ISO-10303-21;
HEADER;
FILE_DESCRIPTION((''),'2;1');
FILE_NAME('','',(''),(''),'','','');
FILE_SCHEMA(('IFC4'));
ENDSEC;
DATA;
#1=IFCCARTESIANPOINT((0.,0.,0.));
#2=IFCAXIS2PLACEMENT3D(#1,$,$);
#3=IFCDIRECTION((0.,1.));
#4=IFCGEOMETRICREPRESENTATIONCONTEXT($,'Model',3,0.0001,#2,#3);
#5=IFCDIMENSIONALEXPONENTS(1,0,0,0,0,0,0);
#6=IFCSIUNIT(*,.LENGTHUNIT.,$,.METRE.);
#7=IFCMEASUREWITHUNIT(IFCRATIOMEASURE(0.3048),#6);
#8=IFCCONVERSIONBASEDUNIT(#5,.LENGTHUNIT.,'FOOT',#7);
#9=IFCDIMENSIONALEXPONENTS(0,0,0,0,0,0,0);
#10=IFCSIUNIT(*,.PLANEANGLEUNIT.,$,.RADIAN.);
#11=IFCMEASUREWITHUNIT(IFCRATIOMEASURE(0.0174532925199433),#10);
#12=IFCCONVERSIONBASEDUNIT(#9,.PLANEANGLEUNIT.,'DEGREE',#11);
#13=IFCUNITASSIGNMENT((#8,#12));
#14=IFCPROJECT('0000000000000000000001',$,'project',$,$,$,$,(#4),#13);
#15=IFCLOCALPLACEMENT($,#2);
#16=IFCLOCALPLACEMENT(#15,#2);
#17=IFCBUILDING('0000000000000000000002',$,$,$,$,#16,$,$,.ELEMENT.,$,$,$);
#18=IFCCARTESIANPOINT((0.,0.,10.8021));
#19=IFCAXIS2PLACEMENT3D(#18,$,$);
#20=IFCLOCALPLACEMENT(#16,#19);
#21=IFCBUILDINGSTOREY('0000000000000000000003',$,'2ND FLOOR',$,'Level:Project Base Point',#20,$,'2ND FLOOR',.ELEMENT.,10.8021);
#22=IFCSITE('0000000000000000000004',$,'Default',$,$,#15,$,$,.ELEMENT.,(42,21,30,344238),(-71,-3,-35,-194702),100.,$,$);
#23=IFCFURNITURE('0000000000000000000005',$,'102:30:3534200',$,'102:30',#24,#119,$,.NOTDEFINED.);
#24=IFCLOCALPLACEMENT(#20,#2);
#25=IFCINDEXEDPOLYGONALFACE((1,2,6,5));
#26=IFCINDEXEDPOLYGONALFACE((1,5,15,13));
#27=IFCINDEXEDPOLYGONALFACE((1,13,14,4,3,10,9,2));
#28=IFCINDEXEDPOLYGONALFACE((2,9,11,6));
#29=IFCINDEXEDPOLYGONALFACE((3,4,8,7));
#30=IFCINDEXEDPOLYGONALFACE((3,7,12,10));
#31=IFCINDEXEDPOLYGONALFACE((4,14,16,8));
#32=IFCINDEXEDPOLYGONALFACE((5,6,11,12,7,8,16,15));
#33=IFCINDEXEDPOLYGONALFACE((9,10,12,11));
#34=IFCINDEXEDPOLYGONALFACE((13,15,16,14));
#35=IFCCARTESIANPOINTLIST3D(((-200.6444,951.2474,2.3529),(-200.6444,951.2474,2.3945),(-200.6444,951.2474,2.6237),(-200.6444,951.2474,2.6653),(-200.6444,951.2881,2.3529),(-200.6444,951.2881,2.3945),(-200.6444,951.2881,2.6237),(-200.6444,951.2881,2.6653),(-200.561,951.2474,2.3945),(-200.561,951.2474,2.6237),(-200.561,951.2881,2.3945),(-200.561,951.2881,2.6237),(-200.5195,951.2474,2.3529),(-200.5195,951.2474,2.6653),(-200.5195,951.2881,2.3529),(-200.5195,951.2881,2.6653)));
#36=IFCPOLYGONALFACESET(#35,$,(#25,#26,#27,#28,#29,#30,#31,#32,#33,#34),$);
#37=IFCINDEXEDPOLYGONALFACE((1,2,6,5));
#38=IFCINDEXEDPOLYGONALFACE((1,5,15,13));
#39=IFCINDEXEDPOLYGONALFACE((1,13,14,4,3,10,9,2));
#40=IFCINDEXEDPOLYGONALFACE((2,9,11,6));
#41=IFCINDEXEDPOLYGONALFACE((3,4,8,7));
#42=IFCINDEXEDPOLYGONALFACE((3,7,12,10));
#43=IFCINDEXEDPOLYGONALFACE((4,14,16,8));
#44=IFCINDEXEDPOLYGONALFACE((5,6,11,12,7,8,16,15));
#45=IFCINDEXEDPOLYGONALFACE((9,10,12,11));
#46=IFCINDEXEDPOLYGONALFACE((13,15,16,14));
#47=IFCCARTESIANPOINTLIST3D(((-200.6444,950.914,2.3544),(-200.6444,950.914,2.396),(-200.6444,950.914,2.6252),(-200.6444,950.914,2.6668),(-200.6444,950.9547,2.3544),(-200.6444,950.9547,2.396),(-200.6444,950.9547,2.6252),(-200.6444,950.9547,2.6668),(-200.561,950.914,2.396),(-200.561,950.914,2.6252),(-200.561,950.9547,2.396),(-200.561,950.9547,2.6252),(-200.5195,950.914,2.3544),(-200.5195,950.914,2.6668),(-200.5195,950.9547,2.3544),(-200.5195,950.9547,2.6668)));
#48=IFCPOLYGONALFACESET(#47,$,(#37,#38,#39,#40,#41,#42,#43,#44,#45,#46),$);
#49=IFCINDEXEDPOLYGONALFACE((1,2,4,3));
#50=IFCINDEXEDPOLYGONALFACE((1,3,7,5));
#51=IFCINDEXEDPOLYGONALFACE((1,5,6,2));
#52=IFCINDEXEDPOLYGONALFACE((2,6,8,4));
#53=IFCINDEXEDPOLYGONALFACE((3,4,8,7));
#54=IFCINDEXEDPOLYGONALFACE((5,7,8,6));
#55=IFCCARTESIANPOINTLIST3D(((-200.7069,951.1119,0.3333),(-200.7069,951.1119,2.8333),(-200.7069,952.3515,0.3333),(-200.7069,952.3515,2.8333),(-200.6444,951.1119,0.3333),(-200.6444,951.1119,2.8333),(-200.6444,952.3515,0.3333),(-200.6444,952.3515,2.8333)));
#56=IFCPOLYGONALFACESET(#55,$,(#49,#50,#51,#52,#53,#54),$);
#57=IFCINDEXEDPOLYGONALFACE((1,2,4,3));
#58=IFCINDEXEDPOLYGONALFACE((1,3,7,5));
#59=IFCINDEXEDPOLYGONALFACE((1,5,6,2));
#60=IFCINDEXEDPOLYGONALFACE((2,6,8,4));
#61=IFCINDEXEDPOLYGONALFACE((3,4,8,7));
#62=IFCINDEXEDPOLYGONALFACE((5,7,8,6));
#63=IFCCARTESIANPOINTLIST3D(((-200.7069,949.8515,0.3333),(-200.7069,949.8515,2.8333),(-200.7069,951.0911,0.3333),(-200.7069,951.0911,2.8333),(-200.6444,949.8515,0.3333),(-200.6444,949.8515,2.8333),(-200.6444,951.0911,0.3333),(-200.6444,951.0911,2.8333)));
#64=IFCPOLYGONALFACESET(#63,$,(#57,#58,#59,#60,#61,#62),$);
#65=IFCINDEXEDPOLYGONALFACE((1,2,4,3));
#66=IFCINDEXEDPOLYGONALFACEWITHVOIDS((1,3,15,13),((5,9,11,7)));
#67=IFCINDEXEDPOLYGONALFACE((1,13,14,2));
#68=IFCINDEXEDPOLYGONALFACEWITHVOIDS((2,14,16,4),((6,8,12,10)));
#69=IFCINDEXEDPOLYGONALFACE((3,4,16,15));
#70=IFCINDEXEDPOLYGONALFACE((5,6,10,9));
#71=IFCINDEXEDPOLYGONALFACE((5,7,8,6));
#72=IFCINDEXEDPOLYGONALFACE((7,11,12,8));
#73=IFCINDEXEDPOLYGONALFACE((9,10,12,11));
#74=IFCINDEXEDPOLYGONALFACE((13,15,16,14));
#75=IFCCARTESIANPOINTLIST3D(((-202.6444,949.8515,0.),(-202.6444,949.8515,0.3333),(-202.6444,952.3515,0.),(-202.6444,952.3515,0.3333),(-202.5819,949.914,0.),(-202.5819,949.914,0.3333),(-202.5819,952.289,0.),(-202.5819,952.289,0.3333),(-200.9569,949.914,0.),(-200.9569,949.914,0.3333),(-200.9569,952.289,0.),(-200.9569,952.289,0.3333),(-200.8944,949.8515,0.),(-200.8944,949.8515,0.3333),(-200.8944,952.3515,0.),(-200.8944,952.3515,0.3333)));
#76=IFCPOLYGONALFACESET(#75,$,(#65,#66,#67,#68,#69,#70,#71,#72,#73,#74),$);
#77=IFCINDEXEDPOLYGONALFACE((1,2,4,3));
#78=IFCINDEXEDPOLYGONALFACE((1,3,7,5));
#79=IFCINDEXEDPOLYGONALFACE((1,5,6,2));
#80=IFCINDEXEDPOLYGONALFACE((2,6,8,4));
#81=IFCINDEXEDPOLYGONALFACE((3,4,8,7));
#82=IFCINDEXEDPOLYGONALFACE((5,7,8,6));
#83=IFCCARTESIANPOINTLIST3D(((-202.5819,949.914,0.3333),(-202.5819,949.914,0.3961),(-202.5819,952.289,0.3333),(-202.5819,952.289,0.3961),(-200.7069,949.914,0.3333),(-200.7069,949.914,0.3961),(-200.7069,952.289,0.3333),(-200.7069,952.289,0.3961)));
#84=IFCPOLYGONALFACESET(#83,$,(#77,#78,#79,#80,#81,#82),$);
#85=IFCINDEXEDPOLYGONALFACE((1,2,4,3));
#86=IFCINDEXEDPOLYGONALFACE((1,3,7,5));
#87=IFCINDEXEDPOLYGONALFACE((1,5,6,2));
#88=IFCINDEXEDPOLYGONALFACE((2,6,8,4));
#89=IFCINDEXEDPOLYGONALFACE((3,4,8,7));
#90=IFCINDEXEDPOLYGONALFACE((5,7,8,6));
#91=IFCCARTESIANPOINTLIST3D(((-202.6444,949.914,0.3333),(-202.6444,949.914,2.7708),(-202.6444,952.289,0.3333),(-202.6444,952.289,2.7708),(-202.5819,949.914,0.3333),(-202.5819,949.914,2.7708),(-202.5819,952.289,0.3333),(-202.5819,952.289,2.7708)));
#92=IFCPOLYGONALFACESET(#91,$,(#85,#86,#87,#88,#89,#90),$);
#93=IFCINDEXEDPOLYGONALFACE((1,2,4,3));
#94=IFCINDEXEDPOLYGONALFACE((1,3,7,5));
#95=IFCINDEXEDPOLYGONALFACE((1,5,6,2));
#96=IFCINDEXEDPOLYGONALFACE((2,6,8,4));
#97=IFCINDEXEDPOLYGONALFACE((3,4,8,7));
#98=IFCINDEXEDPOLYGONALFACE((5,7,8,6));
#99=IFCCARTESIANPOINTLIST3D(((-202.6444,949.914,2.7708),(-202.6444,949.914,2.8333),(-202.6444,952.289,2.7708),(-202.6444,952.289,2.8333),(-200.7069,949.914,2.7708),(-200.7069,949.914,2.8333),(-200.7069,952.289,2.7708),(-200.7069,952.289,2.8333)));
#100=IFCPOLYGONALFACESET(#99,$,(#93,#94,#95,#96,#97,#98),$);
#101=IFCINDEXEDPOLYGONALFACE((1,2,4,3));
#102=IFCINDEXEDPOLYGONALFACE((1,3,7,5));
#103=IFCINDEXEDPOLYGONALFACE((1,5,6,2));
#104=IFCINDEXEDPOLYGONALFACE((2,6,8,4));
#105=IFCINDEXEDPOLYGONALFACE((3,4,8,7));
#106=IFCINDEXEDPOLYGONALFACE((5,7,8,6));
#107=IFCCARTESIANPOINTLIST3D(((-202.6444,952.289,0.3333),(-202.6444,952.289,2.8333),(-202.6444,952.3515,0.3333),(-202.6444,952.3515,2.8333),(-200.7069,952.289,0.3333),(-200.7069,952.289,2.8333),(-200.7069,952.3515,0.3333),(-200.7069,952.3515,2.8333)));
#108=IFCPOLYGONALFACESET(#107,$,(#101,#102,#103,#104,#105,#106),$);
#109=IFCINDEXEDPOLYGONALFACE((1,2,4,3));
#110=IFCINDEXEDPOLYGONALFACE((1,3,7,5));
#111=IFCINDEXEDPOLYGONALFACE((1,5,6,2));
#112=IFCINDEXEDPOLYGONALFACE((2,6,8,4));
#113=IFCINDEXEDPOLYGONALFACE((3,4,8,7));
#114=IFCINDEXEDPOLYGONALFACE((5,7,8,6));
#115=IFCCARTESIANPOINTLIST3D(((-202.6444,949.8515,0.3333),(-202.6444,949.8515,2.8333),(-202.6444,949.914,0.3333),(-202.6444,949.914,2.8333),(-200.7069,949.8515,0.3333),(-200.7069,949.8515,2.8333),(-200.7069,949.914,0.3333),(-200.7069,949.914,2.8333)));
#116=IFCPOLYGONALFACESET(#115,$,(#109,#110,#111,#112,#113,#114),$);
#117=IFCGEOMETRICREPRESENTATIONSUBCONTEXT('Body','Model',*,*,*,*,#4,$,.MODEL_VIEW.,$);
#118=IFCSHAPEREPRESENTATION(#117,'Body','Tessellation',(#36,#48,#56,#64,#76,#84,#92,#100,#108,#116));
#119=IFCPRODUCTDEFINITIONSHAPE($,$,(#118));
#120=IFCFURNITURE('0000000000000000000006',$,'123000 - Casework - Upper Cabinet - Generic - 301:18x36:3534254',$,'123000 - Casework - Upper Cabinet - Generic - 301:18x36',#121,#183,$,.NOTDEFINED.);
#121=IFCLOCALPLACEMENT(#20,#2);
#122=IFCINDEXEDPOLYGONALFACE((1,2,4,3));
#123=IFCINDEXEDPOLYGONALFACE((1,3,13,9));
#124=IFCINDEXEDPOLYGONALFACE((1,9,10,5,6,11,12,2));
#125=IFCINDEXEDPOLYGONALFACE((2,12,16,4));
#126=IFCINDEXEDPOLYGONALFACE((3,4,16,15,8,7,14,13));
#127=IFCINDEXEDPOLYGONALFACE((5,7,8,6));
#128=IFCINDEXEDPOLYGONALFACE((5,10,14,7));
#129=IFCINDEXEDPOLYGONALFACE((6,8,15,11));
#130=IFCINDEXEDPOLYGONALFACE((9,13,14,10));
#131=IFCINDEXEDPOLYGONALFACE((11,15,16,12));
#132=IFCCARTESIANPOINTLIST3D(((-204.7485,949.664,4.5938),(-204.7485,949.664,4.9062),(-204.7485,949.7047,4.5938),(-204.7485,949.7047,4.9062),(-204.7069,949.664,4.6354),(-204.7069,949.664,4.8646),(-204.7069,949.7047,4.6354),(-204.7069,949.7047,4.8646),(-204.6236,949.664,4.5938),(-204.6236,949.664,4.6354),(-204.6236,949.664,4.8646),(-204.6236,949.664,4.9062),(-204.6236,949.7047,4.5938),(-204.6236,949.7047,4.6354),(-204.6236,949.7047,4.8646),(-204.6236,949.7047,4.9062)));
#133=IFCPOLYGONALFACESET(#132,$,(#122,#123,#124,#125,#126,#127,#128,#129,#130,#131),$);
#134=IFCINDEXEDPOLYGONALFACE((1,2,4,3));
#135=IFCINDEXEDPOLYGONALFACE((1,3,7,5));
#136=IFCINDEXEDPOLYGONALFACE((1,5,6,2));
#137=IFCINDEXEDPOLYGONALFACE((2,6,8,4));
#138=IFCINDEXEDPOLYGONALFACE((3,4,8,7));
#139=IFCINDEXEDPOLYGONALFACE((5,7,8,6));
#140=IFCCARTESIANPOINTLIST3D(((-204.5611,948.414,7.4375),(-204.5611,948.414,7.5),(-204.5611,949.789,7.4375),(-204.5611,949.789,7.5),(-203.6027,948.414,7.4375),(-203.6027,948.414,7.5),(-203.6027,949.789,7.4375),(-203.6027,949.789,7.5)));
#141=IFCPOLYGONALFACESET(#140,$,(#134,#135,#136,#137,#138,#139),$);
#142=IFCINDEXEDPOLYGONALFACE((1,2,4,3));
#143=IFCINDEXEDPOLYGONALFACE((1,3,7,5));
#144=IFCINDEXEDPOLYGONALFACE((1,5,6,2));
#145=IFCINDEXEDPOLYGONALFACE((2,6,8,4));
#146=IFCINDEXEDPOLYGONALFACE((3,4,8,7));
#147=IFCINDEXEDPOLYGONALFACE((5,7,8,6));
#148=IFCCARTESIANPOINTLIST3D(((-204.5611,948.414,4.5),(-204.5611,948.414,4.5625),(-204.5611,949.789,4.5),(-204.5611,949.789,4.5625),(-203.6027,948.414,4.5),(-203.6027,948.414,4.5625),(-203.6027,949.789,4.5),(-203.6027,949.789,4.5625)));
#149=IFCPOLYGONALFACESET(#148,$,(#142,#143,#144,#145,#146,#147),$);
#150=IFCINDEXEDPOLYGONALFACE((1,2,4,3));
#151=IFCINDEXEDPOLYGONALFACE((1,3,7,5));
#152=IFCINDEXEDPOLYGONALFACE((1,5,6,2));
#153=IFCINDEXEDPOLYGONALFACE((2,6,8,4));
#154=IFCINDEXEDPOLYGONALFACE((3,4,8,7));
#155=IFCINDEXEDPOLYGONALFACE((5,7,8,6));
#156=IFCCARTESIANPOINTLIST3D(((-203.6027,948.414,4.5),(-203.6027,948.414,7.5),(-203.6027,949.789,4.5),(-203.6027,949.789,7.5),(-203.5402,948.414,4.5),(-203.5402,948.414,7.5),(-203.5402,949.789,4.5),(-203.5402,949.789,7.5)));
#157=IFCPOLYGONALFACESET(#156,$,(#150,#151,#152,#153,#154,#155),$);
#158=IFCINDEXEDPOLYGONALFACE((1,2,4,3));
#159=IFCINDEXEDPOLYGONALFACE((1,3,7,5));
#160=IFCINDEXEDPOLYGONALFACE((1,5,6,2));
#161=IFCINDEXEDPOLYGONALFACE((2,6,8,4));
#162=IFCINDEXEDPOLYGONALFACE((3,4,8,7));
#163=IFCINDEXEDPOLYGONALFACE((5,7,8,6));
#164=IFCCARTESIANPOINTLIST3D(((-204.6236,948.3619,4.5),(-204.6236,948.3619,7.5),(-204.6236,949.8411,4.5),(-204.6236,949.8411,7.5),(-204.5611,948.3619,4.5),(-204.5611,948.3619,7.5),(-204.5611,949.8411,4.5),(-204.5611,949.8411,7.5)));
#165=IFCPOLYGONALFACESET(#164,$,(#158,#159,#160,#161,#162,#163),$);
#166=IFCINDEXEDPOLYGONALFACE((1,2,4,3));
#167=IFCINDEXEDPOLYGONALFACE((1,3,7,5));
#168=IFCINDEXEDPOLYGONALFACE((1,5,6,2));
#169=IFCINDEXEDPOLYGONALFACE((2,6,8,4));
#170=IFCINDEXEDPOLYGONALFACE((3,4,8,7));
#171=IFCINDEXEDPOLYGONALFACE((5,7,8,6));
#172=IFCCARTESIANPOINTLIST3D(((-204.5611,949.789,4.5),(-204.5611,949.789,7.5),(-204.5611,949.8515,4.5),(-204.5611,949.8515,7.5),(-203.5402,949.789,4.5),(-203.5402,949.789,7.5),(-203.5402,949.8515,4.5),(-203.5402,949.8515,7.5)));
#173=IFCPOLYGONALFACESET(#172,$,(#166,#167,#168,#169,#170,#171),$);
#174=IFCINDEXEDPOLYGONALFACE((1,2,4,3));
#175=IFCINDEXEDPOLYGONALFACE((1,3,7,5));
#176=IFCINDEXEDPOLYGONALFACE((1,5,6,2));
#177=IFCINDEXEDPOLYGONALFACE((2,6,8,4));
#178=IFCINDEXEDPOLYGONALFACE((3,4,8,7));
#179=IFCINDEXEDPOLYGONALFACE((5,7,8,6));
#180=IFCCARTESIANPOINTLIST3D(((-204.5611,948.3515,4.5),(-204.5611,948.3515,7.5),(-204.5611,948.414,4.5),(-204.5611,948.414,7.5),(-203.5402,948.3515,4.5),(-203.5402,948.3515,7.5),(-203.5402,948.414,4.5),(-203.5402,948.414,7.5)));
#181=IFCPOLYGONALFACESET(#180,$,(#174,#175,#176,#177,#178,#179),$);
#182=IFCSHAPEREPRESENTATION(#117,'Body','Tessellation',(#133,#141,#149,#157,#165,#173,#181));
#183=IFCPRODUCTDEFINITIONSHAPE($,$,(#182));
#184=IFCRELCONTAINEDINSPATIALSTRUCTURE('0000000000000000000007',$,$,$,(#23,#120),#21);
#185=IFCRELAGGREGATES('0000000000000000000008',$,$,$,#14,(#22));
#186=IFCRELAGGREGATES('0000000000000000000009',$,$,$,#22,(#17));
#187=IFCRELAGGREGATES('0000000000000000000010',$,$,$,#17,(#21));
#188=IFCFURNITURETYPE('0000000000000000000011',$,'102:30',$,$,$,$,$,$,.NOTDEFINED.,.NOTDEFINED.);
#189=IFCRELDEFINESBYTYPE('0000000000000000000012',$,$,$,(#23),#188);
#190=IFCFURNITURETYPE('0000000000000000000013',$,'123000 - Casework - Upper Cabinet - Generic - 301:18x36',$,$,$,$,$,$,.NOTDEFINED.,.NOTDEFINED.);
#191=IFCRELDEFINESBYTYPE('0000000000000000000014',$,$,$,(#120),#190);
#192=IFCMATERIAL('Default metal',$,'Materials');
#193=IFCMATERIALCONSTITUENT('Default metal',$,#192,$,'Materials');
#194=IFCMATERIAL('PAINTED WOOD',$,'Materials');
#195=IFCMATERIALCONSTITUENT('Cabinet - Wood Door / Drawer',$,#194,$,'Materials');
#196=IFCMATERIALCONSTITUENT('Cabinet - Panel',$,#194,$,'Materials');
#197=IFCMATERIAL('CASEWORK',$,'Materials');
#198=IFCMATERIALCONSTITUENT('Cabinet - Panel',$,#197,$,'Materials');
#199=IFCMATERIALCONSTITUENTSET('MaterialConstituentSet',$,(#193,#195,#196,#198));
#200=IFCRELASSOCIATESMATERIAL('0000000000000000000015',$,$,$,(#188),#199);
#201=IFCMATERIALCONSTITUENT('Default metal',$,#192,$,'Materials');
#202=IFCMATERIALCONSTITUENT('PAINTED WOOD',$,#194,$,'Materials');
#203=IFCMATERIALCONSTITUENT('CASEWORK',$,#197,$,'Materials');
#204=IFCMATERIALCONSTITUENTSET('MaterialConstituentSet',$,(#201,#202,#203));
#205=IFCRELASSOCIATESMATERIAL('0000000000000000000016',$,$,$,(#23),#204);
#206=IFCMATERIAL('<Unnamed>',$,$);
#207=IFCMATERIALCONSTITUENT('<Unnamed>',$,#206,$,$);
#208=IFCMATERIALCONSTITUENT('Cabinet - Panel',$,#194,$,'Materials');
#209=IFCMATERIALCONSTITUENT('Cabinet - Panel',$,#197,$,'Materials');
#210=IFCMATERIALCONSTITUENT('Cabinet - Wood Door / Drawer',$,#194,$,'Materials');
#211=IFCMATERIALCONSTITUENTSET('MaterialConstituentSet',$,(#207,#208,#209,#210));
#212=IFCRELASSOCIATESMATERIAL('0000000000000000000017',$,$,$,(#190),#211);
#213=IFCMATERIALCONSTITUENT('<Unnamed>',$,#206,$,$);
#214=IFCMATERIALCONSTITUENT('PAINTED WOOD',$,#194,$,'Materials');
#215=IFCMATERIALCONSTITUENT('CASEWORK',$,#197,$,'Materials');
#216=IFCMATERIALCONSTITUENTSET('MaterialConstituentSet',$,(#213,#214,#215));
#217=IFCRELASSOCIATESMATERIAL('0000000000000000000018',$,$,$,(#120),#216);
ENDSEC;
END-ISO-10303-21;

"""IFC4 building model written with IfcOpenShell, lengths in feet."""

from ifc_helpers import new_model, entity, si_unit, converted_unit, direction, frame, frame_2d, origin, origin_2d_with_axis, place, context, subcontext, project, spatial, polyline, rectangle, outline, extrude, source, transform, mapped, material, constituent, constituent_set, type_object, type_shapes, element, save


model = new_model("IFC4")

# Units and contexts
model_context = context("Model", 3, precision=0.0001, world=origin(), true_north=direction((0.0, 1.0)))
body_context = subcontext(model_context, "Body", "Model", "MODEL_VIEW")
ifc_project = project(units=[converted_unit("LENGTHUNIT", "FOOT", entity("IfcRatioMeasure", 0.3048), si_unit("LENGTHUNIT", "METRE"), dimensions=[1, 0, 0, 0, 0, 0, 0]), converted_unit("PLANEANGLEUNIT", "DEGREE", entity("IfcRatioMeasure", 0.0174532925199433), si_unit("PLANEANGLEUNIT", "RADIAN"), dimensions=[0, 0, 0, 0, 0, 0, 0])], contexts=[model_context])

# Site, building, storey
site_placement = place(None, origin())
site = spatial("IfcSite", under=ifc_project, at=site_placement, Name="Default", CompositionType="ELEMENT", RefLatitude=(42, 21, 30, 344238), RefLongitude=(-71, -3, -35, -194702), RefElevation=100.0)
building_placement = place(site_placement, origin())
building = spatial("IfcBuilding", under=site, at=building_placement, CompositionType="ELEMENT")
storey_placement = place(building_placement, frame((0.0, 0.0, 10.8021)))
storey = spatial("IfcBuildingStorey", under=building, at=storey_placement, Name="2ND FLOOR", ObjectType="Level:Project Base Point", LongName="2ND FLOOR", CompositionType="ELEMENT", Elevation=10.8021)

# Furniture
ifc_material_1 = material(Name="<Unnamed>")
ifc_material_2 = material(Name="CASEWORK", Category="Materials")
ifc_material_3 = material(Name="PAINTED WOOD", Category="Materials")
ifc_material_4 = material(Name="Default metal", Category="Materials")
ifc_constituent_1 = constituent(ifc_material_4, Name="Default metal", Category="Materials")
ifc_constituent_2 = constituent(ifc_material_3, Name="PAINTED WOOD", Category="Materials")
ifc_constituent_3 = constituent(ifc_material_2, Name="CASEWORK", Category="Materials")
ifc_constituent_set_1 = constituent_set(constituents=[ifc_constituent_1, ifc_constituent_2, ifc_constituent_3], Name="MaterialConstituentSet")
ifc_constituent_4 = constituent(ifc_material_4, Name="Default metal", Category="Materials")
ifc_constituent_5 = constituent(ifc_material_3, Name="Cabinet - Wood Door / Drawer", Category="Materials")
ifc_constituent_6 = constituent(ifc_material_3, Name="Cabinet - Panel", Category="Materials")
ifc_constituent_7 = constituent(ifc_material_2, Name="Cabinet - Panel", Category="Materials")
ifc_constituent_set_2 = constituent_set(constituents=[ifc_constituent_4, ifc_constituent_5, ifc_constituent_6, ifc_constituent_7], Name="MaterialConstituentSet")
furniture_type_1 = type_object("IfcFurnitureType", Name="102:30", AssemblyPlace="NOTDEFINED", PredefinedType="NOTDEFINED", material=ifc_constituent_set_2)
shared_shape_1 = source(origin(), body_context, "Body", "SweptSolid", [
    extrude(outline(polyline([(0.1146, -0.0521), (0.1562, -0.0521), (0.1562, 0.0729), (-0.1562, 0.0729), (-0.1562, -0.0521), (-0.1146, -0.0521), (-0.1146, 0.0313), (0.1146, 0.0313), (0.1146, -0.0521)])), frame((0.2073, -2.0521, 2.5091), z_axis=(1.0, 0.0, 0.0), x_axis=(0.0, 0.0, 1.0)), (0.0, 0.0, 1.0), 0.0407),
    extrude(outline(polyline([(0.1146, -0.0521), (0.1562, -0.0521), (0.1562, 0.0729), (-0.1562, 0.0729), (-0.1562, -0.0521), (-0.1146, -0.0521), (-0.1146, 0.0313), (0.1146, 0.0313), (0.1146, -0.0521)])), frame((-0.126, -2.0521, 2.5106), z_axis=(1.0, 0.0, 0.0), x_axis=(0.0, 0.0, 1.0)), (0.0, 0.0, 1.0), 0.0407),
    extrude(rectangle(XDim=0.0625, YDim=1.2396, at=frame_2d((0.0, 0.0), x_axis=(1.0, 0.0))), frame((0.6917, -1.9688, 0.3333), z_axis=(0.0, 0.0, 1.0), x_axis=(0.0, 1.0, 0.0)), (0.0, 0.0, 1.0), 2.5),
    extrude(rectangle(XDim=0.0625, YDim=1.2396, at=origin_2d_with_axis()), frame((-0.5687, -1.9688, 0.3333), z_axis=(0.0, 0.0, 1.0), x_axis=(0.0, 1.0, 0.0)), (0.0, 0.0, 1.0), 2.5),
    extrude(outline(polyline([(-1.25, -0.875), (1.25, -0.875), (1.25, 0.875), (-1.25, 0.875), (-1.25, -0.875)]), holes=[polyline([(-1.1875, -0.8125), (-1.1875, 0.8125), (1.1875, 0.8125), (1.1875, -0.8125), (-1.1875, -0.8125)])]), frame((0.0615, -0.875, 0.0)), (0.0, 0.0, 1.0), 0.3333),
    extrude(rectangle(XDim=2.375, YDim=1.875, at=frame_2d((0.0, 0.0), x_axis=(1.0, 0.0))), frame((0.0615, -1.0, 0.3333), z_axis=(0.0, 0.0, 1.0), x_axis=(-1.0, 0.0, 0.0)), (0.0, 0.0, 1.0), 0.0627),
    extrude(rectangle(XDim=0.0625, YDim=2.375, at=origin_2d_with_axis()), frame((0.0615, -0.0312, 0.3333), z_axis=(0.0, 0.0, 1.0), x_axis=(0.0, 1.0, 0.0)), (0.0, 0.0, 1.0), 2.4375),
    extrude(rectangle(XDim=2.375, YDim=1.9375, at=origin_2d_with_axis()), frame((0.0615, -0.9688, 2.7708), z_axis=(0.0, 0.0, 1.0), x_axis=(-1.0, 0.0, 0.0)), (0.0, 0.0, 1.0), 0.0625),
    extrude(rectangle(XDim=0.0625, YDim=1.9375, at=frame_2d((0.0, 0.0), x_axis=(1.0, 0.0))), frame((1.2802, -0.9687, 0.3333)), (0.0, 0.0, 1.0), 2.5),
    extrude(rectangle(XDim=0.0625, YDim=1.9375, at=frame_2d((0.0, 0.0), x_axis=(1.0, 0.0))), frame((-1.1573, -0.9687, 0.3333)), (0.0, 0.0, 1.0), 2.5),
])
type_shapes(furniture_type_1, [shared_shape_1])
furniture_1_placement = place(storey_placement, frame((-202.6444, 951.04, 0.0), z_axis=(0.0, 0.0, 1.0), x_axis=(0.0, 1.0, 0.0)))
element("IfcFurniture", 1, at=furniture_1_placement, inside=storey, type_object=furniture_type_1, material=ifc_constituent_set_1, Name="102:30:3534200", ObjectType="102:30", PredefinedType="NOTDEFINED", context=body_context, shape_type="MappedRepresentation", body=[
    mapped(shared_shape_1, transform((0.0, 0.0, 0.0), scale=1.0)),
])
ifc_constituent_8 = constituent(ifc_material_1, Name="<Unnamed>")
ifc_constituent_9 = constituent(ifc_material_3, Name="PAINTED WOOD", Category="Materials")
ifc_constituent_10 = constituent(ifc_material_2, Name="CASEWORK", Category="Materials")
ifc_constituent_set_3 = constituent_set(constituents=[ifc_constituent_8, ifc_constituent_9, ifc_constituent_10], Name="MaterialConstituentSet")
ifc_constituent_11 = constituent(ifc_material_1, Name="<Unnamed>")
ifc_constituent_12 = constituent(ifc_material_3, Name="Cabinet - Panel", Category="Materials")
ifc_constituent_13 = constituent(ifc_material_2, Name="Cabinet - Panel", Category="Materials")
ifc_constituent_14 = constituent(ifc_material_3, Name="Cabinet - Wood Door / Drawer", Category="Materials")
ifc_constituent_set_4 = constituent_set(constituents=[ifc_constituent_11, ifc_constituent_12, ifc_constituent_13, ifc_constituent_14], Name="MaterialConstituentSet")
furniture_type_2 = type_object("IfcFurnitureType", Name="123000 - Casework - Upper Cabinet - Generic - 301:18x36", AssemblyPlace="NOTDEFINED", PredefinedType="NOTDEFINED", material=ifc_constituent_set_4)
shared_shape_2 = source(origin(), body_context, "Body", "SweptSolid", [
    extrude(outline(polyline([(0.1146, -0.0521), (0.1562, -0.0521), (0.1562, 0.0729), (-0.1562, 0.0729), (-0.1562, -0.0521), (-0.1146, -0.0521), (-0.1146, 0.0313), (0.1146, 0.0313), (0.1146, -0.0521)])), frame((0.1468, 0.0729, 0.25), z_axis=(1.0, 0.0, 0.0), x_axis=(0.0, 0.0, 1.0)), (0.0, 0.0, 1.0), 0.0407),
    extrude(rectangle(XDim=1.375, YDim=0.9583, at=frame_2d((0.0, 0.0), x_axis=(1.0, 0.0))), frame((0.75, 0.6666, 2.9375), z_axis=(0.0, 0.0, 1.0), x_axis=(-1.0, 0.0, 0.0)), (0.0, 0.0, 1.0), 0.0625),
    extrude(rectangle(XDim=1.375, YDim=0.9583, at=frame_2d((0.0, 0.0), x_axis=(1.0, 0.0))), frame((0.75, 0.6666, 0.0), z_axis=(0.0, 0.0, 1.0), x_axis=(-1.0, 0.0, 0.0)), (0.0, 0.0, 1.0), 0.0625),
    extrude(rectangle(XDim=0.0625, YDim=1.375, at=origin_2d_with_axis()), frame((0.75, 1.177, 0.0), z_axis=(0.0, 0.0, 1.0), x_axis=(0.0, 1.0, 0.0)), (0.0, 0.0, 1.0), 3.0),
    extrude(rectangle(XDim=0.0625, YDim=1.4792, at=origin_2d_with_axis()), frame((0.75, 0.1562, 0.0), z_axis=(0.0, 0.0, 1.0), x_axis=(0.0, -1.0, 0.0)), (0.0, 0.0, 1.0), 3.0),
    extrude(rectangle(XDim=0.0625, YDim=1.0208, at=origin_2d_with_axis()), frame((0.0312, 0.6979, 0.0), z_axis=(0.0, 0.0, 1.0), x_axis=(-1.0, 0.0, 0.0)), (0.0, 0.0, 1.0), 3.0),
    extrude(rectangle(XDim=0.0625, YDim=1.0208, at=origin_2d_with_axis()), frame((1.4688, 0.6979, 0.0), z_axis=(0.0, 0.0, 1.0), x_axis=(-1.0, 0.0, 0.0)), (0.0, 0.0, 1.0), 3.0),
])
type_shapes(furniture_type_2, [shared_shape_2])
furniture_2_placement = place(storey_placement, frame((-204.7485, 949.8515, 4.5), z_axis=(0.0, 0.0, 1.0), x_axis=(0.0, -1.0, 0.0)))
element("IfcFurniture", 2, at=furniture_2_placement, inside=storey, type_object=furniture_type_2, material=ifc_constituent_set_3, Name="123000 - Casework - Upper Cabinet - Generic - 301:18x36:3534254", ObjectType="123000 - Casework - Upper Cabinet - Generic - 301:18x36", PredefinedType="NOTDEFINED", context=body_context, shape_type="MappedRepresentation", body=[
    mapped(shared_shape_2, transform((0.0, 0.0, 0.0), scale=1.0)),
])

save(model, "model.ifc")
